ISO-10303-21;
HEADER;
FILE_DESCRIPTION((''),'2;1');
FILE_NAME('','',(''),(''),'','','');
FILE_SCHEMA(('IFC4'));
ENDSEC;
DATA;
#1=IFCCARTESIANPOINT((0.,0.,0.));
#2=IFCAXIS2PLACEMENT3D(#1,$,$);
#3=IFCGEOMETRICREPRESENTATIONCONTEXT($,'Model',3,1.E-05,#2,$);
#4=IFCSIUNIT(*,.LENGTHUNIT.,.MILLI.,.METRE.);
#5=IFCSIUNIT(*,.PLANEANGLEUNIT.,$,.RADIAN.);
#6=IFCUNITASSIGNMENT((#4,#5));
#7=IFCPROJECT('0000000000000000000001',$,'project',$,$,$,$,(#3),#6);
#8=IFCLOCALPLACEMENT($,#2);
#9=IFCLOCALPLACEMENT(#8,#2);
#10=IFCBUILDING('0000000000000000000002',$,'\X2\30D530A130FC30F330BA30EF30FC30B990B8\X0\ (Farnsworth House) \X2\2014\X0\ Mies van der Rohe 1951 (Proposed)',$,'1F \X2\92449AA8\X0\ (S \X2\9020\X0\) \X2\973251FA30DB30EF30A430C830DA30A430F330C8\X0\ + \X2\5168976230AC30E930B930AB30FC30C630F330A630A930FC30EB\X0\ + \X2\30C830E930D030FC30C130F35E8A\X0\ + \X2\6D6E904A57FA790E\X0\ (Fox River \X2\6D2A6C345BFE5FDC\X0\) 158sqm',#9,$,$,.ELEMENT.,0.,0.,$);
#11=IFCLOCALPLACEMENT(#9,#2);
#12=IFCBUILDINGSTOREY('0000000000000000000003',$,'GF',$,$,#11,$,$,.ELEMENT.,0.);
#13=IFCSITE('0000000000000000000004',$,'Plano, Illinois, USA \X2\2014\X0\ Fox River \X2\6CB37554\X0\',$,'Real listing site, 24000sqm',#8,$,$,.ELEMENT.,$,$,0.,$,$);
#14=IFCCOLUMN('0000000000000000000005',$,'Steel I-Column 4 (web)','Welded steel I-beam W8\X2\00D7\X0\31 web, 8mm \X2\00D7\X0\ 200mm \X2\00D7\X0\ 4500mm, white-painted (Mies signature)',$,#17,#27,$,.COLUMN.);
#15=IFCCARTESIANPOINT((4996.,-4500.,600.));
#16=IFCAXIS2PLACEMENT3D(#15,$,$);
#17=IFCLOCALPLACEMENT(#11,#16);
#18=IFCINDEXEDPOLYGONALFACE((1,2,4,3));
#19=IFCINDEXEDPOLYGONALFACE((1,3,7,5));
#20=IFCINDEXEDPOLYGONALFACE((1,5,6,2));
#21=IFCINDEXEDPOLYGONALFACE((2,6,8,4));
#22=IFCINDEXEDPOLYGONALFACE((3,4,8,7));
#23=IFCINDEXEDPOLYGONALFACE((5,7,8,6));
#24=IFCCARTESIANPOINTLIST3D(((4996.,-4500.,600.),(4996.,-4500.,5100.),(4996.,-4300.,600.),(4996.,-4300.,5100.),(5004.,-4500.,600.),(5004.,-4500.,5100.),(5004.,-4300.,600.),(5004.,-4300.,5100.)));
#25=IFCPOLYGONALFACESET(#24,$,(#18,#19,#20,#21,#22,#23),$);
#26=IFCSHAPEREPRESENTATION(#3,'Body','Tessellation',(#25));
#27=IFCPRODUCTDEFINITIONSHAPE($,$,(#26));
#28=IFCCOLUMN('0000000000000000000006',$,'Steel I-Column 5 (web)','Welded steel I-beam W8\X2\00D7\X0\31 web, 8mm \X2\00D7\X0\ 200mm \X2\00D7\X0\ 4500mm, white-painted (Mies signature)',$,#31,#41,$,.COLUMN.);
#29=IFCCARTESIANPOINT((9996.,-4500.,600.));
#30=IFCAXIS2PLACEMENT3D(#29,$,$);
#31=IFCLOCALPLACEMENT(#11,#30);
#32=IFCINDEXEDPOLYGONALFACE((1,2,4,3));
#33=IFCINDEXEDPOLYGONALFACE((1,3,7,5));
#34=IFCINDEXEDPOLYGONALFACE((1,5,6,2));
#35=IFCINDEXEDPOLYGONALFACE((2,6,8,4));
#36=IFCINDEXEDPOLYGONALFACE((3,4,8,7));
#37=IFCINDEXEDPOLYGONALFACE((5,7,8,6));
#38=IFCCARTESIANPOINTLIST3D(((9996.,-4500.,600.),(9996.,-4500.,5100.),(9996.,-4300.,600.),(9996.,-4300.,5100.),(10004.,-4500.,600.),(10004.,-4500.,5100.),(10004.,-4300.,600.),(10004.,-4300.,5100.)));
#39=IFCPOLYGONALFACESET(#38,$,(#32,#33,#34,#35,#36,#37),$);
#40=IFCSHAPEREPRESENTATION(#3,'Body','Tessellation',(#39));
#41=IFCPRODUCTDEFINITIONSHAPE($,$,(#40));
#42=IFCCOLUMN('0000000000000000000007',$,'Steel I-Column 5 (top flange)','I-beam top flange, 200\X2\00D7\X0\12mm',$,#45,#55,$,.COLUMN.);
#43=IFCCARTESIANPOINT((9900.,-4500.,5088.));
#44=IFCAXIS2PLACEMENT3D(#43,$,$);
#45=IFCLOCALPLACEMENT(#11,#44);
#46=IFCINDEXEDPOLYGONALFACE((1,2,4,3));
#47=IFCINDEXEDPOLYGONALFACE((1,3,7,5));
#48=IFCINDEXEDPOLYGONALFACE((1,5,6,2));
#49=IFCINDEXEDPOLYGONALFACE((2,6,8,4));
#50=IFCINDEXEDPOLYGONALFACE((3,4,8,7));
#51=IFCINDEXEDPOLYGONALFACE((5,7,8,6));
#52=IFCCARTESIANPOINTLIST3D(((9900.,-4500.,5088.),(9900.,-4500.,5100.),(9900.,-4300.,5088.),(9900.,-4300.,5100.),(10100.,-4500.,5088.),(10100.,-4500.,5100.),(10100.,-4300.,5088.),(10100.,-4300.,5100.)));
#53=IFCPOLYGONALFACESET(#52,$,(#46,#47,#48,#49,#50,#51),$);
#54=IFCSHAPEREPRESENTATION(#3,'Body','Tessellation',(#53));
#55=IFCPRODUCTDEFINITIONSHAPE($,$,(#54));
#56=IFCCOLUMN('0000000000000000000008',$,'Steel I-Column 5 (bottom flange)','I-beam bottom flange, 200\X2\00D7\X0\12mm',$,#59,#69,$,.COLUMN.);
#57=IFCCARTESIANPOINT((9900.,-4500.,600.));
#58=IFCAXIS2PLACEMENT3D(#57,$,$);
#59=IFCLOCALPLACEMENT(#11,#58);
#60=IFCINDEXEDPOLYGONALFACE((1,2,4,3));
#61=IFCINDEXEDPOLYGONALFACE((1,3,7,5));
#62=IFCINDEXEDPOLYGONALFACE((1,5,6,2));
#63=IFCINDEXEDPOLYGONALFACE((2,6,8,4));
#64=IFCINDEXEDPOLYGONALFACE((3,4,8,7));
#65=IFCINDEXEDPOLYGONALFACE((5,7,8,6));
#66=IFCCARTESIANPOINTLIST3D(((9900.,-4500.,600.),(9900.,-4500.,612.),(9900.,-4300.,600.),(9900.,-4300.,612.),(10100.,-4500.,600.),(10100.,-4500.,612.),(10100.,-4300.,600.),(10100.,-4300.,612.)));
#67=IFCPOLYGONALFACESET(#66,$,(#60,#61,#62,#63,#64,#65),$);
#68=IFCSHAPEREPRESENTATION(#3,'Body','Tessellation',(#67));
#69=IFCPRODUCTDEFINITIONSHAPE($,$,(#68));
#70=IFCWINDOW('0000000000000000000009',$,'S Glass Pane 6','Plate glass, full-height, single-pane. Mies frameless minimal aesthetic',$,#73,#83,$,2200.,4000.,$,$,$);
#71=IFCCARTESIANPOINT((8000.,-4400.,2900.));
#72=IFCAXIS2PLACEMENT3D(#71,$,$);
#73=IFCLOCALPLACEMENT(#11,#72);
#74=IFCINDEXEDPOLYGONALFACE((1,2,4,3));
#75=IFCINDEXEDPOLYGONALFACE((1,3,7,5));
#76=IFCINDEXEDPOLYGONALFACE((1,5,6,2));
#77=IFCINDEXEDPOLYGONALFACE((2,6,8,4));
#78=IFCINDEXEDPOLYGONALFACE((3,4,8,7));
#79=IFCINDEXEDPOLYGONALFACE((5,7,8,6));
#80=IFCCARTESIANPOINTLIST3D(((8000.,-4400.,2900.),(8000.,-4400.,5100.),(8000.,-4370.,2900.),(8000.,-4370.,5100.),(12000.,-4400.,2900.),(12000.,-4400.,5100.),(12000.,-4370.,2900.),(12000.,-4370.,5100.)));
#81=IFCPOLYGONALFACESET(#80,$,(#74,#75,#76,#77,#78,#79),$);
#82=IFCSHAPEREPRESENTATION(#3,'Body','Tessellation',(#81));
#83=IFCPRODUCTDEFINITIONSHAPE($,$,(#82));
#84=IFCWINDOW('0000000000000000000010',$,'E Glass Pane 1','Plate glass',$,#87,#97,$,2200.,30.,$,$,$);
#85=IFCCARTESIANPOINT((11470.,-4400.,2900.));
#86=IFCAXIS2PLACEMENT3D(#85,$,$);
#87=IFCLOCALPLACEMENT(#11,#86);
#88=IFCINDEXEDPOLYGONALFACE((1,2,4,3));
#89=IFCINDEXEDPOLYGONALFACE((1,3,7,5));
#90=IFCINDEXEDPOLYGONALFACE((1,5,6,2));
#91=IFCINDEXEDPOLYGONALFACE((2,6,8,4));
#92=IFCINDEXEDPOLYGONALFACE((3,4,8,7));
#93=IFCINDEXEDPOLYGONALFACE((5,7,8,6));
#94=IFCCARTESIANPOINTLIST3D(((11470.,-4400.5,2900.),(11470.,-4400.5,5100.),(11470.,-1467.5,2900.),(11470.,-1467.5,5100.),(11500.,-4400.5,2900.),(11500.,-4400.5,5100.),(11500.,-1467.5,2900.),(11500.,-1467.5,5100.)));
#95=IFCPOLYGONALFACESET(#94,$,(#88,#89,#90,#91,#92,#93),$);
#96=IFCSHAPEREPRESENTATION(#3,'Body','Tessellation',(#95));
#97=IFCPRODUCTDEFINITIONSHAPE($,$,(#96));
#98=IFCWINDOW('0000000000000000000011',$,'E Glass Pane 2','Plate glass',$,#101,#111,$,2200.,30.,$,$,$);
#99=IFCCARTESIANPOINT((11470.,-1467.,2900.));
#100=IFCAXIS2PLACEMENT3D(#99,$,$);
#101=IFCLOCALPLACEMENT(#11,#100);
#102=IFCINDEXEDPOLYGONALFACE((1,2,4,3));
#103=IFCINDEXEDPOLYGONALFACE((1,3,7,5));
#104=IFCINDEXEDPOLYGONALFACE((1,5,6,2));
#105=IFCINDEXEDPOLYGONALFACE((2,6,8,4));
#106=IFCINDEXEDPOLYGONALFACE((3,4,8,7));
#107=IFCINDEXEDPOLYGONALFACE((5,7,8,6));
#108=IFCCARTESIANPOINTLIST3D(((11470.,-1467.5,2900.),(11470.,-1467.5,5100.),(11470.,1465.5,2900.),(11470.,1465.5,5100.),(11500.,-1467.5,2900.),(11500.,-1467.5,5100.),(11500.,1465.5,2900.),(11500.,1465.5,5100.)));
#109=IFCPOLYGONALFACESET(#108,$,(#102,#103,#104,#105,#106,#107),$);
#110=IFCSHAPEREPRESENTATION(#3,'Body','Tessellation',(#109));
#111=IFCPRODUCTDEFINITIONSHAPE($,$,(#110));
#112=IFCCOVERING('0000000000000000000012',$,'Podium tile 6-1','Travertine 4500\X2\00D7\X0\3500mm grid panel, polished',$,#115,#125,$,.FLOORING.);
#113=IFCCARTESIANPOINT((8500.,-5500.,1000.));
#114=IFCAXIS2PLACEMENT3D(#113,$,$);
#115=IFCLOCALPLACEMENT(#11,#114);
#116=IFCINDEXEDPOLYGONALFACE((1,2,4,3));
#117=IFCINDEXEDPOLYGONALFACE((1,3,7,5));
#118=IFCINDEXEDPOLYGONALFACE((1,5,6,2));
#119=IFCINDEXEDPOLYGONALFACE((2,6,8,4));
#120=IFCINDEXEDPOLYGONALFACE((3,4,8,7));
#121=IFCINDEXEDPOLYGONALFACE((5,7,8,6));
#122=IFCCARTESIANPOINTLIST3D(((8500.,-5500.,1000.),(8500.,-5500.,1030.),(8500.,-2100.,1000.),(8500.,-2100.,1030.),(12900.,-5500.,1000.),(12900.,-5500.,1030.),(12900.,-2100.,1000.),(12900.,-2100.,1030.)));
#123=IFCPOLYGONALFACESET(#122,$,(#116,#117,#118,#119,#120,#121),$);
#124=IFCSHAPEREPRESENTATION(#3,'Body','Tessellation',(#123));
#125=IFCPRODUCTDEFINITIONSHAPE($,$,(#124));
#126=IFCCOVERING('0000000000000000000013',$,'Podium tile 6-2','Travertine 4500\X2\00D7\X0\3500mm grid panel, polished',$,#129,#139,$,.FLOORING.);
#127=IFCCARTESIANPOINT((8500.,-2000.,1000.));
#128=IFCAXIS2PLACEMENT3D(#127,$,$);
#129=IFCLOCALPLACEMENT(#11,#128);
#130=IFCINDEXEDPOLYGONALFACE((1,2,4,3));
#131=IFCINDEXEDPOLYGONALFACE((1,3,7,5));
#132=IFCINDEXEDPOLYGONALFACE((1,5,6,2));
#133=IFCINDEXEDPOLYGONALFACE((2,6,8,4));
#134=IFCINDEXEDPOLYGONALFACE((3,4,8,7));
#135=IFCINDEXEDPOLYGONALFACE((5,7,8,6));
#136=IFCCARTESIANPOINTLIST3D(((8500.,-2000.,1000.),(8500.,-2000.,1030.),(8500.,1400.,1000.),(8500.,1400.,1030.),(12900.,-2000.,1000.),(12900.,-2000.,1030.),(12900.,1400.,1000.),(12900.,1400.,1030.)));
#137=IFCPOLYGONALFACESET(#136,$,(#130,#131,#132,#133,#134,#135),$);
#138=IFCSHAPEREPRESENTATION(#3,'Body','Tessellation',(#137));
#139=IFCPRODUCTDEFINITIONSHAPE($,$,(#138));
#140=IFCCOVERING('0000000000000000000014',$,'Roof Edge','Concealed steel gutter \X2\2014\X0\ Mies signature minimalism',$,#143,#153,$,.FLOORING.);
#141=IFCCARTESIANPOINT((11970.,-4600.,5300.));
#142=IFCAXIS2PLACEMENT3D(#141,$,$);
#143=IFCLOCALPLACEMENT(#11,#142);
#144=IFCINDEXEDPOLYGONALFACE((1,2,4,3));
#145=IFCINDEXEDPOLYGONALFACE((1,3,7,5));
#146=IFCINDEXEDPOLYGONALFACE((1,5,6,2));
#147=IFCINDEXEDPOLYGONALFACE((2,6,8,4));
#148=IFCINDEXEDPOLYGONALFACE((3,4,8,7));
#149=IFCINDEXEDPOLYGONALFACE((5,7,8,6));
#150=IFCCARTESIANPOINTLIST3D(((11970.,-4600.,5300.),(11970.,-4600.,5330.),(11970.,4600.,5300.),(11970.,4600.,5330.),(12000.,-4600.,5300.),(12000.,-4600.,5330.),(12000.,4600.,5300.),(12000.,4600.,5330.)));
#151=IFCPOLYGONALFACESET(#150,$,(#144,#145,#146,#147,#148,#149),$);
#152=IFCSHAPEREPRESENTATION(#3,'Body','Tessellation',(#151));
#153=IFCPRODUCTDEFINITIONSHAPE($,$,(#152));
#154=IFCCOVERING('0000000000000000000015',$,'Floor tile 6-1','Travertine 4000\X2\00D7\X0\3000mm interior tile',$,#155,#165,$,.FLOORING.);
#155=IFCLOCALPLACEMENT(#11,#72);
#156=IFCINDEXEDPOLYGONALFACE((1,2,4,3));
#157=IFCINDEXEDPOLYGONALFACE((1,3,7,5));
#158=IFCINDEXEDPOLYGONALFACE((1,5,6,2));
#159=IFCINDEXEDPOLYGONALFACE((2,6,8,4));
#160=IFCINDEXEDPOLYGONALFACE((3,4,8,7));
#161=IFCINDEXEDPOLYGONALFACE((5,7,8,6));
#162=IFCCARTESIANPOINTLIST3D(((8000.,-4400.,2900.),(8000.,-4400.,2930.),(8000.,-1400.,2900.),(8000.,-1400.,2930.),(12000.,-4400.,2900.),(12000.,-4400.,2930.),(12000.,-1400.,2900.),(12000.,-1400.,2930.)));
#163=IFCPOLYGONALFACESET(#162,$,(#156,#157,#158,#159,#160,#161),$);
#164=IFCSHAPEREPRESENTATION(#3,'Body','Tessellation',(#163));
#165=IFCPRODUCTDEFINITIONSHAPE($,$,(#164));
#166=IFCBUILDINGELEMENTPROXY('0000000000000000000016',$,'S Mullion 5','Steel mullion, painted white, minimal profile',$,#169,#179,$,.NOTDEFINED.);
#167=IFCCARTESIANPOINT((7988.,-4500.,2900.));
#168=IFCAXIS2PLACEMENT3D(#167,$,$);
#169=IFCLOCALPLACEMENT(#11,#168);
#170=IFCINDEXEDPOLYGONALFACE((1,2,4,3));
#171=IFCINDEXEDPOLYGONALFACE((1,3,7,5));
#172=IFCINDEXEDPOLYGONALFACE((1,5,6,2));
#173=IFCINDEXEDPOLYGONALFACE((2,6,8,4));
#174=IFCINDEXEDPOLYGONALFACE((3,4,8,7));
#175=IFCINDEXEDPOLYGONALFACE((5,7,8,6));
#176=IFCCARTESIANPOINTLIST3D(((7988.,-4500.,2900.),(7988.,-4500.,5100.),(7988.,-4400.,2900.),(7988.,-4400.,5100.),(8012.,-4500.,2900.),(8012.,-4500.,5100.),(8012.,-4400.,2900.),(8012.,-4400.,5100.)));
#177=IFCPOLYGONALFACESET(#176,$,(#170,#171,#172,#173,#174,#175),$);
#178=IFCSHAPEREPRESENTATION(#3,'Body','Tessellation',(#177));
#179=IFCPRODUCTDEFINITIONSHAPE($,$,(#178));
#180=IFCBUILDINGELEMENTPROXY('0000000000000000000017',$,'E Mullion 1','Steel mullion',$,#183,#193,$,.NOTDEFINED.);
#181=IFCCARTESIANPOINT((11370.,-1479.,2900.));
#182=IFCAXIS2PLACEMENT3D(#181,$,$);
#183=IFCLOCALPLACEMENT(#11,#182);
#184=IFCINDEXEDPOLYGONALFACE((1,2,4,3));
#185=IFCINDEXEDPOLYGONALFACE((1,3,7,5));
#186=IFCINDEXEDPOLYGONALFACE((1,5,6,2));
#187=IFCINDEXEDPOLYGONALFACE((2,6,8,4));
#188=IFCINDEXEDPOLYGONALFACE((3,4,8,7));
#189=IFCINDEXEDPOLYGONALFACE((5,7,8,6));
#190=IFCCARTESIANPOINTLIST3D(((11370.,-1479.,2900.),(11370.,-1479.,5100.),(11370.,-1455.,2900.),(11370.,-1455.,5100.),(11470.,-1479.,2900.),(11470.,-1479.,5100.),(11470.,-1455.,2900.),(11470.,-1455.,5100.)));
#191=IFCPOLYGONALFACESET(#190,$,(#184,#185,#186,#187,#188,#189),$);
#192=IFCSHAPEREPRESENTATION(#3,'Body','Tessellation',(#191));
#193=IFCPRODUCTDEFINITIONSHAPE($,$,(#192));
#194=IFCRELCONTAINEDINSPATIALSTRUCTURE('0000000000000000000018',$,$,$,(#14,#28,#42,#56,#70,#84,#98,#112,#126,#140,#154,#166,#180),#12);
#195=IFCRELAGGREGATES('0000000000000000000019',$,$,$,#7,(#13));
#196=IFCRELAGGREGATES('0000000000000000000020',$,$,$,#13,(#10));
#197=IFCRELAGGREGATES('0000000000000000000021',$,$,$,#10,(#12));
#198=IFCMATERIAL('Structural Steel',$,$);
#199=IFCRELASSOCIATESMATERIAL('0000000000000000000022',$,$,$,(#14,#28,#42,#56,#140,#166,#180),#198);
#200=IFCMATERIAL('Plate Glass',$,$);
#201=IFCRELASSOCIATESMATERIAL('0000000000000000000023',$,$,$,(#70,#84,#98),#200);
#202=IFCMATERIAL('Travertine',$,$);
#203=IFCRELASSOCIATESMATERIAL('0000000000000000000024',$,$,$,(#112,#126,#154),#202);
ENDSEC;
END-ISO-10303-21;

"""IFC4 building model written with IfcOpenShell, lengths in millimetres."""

from ifc_helpers import new_model, si_unit, frame, frame_2d, origin, place, context, project, spatial, rectangle, extrude, material, element, save


model = new_model("IFC4")

# Units and contexts
model_context = context("Model", 3, precision=1e-05, world=origin())
ifc_project = project(units=[si_unit("LENGTHUNIT", "METRE", prefix="MILLI"), si_unit("PLANEANGLEUNIT", "RADIAN")], contexts=[model_context])

# Site, building, storey
site_placement = place(None, origin())
site = spatial("IfcSite", under=ifc_project, at=site_placement, Name="Plano, Illinois, USA — Fox River 河畔", ObjectType="Real listing site, 24000sqm", CompositionType="ELEMENT", RefElevation=0.0)
building_placement = place(site_placement, origin())
building = spatial("IfcBuilding", under=site, at=building_placement, Name="ファーンズワース邸 (Farnsworth House) — Mies van der Rohe 1951 (Proposed)", ObjectType="1F 鉄骨 (S 造) 露出ホワイトペイント + 全面ガラスカーテンウォール + トラバーチン床 + 浮遊基礎 (Fox River 洪水対応) 158sqm", CompositionType="ELEMENT", ElevationOfRefHeight=0.0, ElevationOfTerrain=0.0)
storey_placement = place(building_placement, origin())
storey = spatial("IfcBuildingStorey", under=building, at=storey_placement, Name="GF", CompositionType="ELEMENT", Elevation=0.0)

# Columns
ifc_material_1 = material(Name="Structural Steel")
column_1_placement = place(storey_placement, frame((4996.0, -4500.0, 600.0)))
element("IfcColumn", 1, at=column_1_placement, inside=storey, material=ifc_material_1, Name="Steel I-Column 4 (web)", Description="Welded steel I-beam W8×31 web, 8mm × 200mm × 4500mm, white-painted (Mies signature)", PredefinedType="COLUMN", context=model_context, shape_type="SweptSolid", body=[
    extrude(rectangle(XDim=8.0, YDim=200.0, at=frame_2d((4.0, 100.0))), frame((4996.0, -4500.0, 600.0)), (0.0, 0.0, 1.0), 4500.0),
])
column_2_placement = place(storey_placement, frame((9996.0, -4500.0, 600.0)))
element("IfcColumn", 2, at=column_2_placement, inside=storey, material=ifc_material_1, Name="Steel I-Column 5 (web)", Description="Welded steel I-beam W8×31 web, 8mm × 200mm × 4500mm, white-painted (Mies signature)", PredefinedType="COLUMN", context=model_context, shape_type="SweptSolid", body=[
    extrude(rectangle(XDim=8.0, YDim=200.0, at=frame_2d((4.0, 100.0))), frame((9996.0, -4500.0, 600.0)), (0.0, 0.0, 1.0), 4500.0),
])
column_3_placement = place(storey_placement, frame((9900.0, -4500.0, 5088.0)))
element("IfcColumn", 3, at=column_3_placement, inside=storey, material=ifc_material_1, Name="Steel I-Column 5 (top flange)", Description="I-beam top flange, 200×12mm", PredefinedType="COLUMN", context=model_context, shape_type="SweptSolid", body=[
    extrude(rectangle(XDim=200.0, YDim=200.0, at=frame_2d((100.0, 100.0))), frame((9900.0, -4500.0, 5088.0)), (0.0, 0.0, 1.0), 12.0),
])
column_4_placement = place(storey_placement, frame((9900.0, -4500.0, 600.0)))
element("IfcColumn", 4, at=column_4_placement, inside=storey, material=ifc_material_1, Name="Steel I-Column 5 (bottom flange)", Description="I-beam bottom flange, 200×12mm", PredefinedType="COLUMN", context=model_context, shape_type="SweptSolid", body=[
    extrude(rectangle(XDim=200.0, YDim=200.0, at=frame_2d((100.0, 100.0))), frame((9900.0, -4500.0, 600.0)), (0.0, 0.0, 1.0), 12.0),
])

# Windows
ifc_material_2 = material(Name="Plate Glass")
window_1_placement = place(storey_placement, frame((8000.0, -4400.0, 2900.0)))
element("IfcWindow", 5, at=window_1_placement, inside=storey, material=ifc_material_2, Name="S Glass Pane 6", Description="Plate glass, full-height, single-pane. Mies frameless minimal aesthetic", OverallHeight=2200.0, OverallWidth=4000.0, context=model_context, shape_type="SweptSolid", body=[
    extrude(rectangle(XDim=4000.0, YDim=30.0, at=frame_2d((2000.0, 15.0))), frame((8000.0, -4400.0, 2900.0)), (0.0, 0.0, 1.0), 2200.0),
])
window_2_placement = place(storey_placement, frame((11470.0, -4400.0, 2900.0)))
element("IfcWindow", 6, at=window_2_placement, inside=storey, material=ifc_material_2, Name="E Glass Pane 1", Description="Plate glass", OverallHeight=2200.0, OverallWidth=30.0, context=model_context, shape_type="SweptSolid", body=[
    extrude(rectangle(XDim=30.0, YDim=2933.0, at=frame_2d((15.0, 1466.0))), frame((11470.0, -4400.0, 2900.0)), (0.0, 0.0, 1.0), 2200.0),
])
window_3_placement = place(storey_placement, frame((11470.0, -1467.0, 2900.0)))
element("IfcWindow", 7, at=window_3_placement, inside=storey, material=ifc_material_2, Name="E Glass Pane 2", Description="Plate glass", OverallHeight=2200.0, OverallWidth=30.0, context=model_context, shape_type="SweptSolid", body=[
    extrude(rectangle(XDim=30.0, YDim=2933.0, at=frame_2d((15.0, 1466.0))), frame((11470.0, -1467.0, 2900.0)), (0.0, 0.0, 1.0), 2200.0),
])

# Coverings
ifc_material_3 = material(Name="Travertine")
covering_1_placement = place(storey_placement, frame((8500.0, -5500.0, 1000.0)))
element("IfcCovering", 8, at=covering_1_placement, inside=storey, material=ifc_material_3, Name="Podium tile 6-1", Description="Travertine 4500×3500mm grid panel, polished", PredefinedType="FLOORING", context=model_context, shape_type="SweptSolid", body=[
    extrude(rectangle(XDim=4400.0, YDim=3400.0, at=frame_2d((2200.0, 1700.0))), frame((8500.0, -5500.0, 1000.0)), (0.0, 0.0, 1.0), 30.0),
])
covering_2_placement = place(storey_placement, frame((8500.0, -2000.0, 1000.0)))
element("IfcCovering", 9, at=covering_2_placement, inside=storey, material=ifc_material_3, Name="Podium tile 6-2", Description="Travertine 4500×3500mm grid panel, polished", PredefinedType="FLOORING", context=model_context, shape_type="SweptSolid", body=[
    extrude(rectangle(XDim=4400.0, YDim=3400.0, at=frame_2d((2200.0, 1700.0))), frame((8500.0, -2000.0, 1000.0)), (0.0, 0.0, 1.0), 30.0),
])
covering_3_placement = place(storey_placement, frame((11970.0, -4600.0, 5300.0)))
element("IfcCovering", 10, at=covering_3_placement, inside=storey, material=ifc_material_1, Name="Roof Edge", Description="Concealed steel gutter — Mies signature minimalism", PredefinedType="FLOORING", context=model_context, shape_type="SweptSolid", body=[
    extrude(rectangle(XDim=30.0, YDim=9200.0, at=frame_2d((15.0, 4600.0))), frame((11970.0, -4600.0, 5300.0)), (0.0, 0.0, 1.0), 30.0),
])
covering_4_placement = place(storey_placement, frame((8000.0, -4400.0, 2900.0)))
element("IfcCovering", 11, at=covering_4_placement, inside=storey, material=ifc_material_3, Name="Floor tile 6-1", Description="Travertine 4000×3000mm interior tile", PredefinedType="FLOORING", context=model_context, shape_type="SweptSolid", body=[
    extrude(rectangle(XDim=4000.0, YDim=3000.0, at=frame_2d((2000.0, 1500.0))), frame((8000.0, -4400.0, 2900.0)), (0.0, 0.0, 1.0), 30.0),
])

# Building element proxies
proxy_1_placement = place(storey_placement, frame((7988.0, -4500.0, 2900.0)))
element("IfcBuildingElementProxy", 12, at=proxy_1_placement, inside=storey, material=ifc_material_1, Name="S Mullion 5", Description="Steel mullion, painted white, minimal profile", PredefinedType="NOTDEFINED", context=model_context, shape_type="SweptSolid", body=[
    extrude(rectangle(XDim=24.0, YDim=100.0, at=frame_2d((12.0, 50.0))), frame((7988.0, -4500.0, 2900.0)), (0.0, 0.0, 1.0), 2200.0),
])
proxy_2_placement = place(storey_placement, frame((11370.0, -1479.0, 2900.0)))
element("IfcBuildingElementProxy", 13, at=proxy_2_placement, inside=storey, material=ifc_material_1, Name="E Mullion 1", Description="Steel mullion", PredefinedType="NOTDEFINED", context=model_context, shape_type="SweptSolid", body=[
    extrude(rectangle(XDim=100.0, YDim=24.0, at=frame_2d((50.0, 12.0))), frame((11370.0, -1479.0, 2900.0)), (0.0, 0.0, 1.0), 2200.0),
])

save(model, "model.ifc")
